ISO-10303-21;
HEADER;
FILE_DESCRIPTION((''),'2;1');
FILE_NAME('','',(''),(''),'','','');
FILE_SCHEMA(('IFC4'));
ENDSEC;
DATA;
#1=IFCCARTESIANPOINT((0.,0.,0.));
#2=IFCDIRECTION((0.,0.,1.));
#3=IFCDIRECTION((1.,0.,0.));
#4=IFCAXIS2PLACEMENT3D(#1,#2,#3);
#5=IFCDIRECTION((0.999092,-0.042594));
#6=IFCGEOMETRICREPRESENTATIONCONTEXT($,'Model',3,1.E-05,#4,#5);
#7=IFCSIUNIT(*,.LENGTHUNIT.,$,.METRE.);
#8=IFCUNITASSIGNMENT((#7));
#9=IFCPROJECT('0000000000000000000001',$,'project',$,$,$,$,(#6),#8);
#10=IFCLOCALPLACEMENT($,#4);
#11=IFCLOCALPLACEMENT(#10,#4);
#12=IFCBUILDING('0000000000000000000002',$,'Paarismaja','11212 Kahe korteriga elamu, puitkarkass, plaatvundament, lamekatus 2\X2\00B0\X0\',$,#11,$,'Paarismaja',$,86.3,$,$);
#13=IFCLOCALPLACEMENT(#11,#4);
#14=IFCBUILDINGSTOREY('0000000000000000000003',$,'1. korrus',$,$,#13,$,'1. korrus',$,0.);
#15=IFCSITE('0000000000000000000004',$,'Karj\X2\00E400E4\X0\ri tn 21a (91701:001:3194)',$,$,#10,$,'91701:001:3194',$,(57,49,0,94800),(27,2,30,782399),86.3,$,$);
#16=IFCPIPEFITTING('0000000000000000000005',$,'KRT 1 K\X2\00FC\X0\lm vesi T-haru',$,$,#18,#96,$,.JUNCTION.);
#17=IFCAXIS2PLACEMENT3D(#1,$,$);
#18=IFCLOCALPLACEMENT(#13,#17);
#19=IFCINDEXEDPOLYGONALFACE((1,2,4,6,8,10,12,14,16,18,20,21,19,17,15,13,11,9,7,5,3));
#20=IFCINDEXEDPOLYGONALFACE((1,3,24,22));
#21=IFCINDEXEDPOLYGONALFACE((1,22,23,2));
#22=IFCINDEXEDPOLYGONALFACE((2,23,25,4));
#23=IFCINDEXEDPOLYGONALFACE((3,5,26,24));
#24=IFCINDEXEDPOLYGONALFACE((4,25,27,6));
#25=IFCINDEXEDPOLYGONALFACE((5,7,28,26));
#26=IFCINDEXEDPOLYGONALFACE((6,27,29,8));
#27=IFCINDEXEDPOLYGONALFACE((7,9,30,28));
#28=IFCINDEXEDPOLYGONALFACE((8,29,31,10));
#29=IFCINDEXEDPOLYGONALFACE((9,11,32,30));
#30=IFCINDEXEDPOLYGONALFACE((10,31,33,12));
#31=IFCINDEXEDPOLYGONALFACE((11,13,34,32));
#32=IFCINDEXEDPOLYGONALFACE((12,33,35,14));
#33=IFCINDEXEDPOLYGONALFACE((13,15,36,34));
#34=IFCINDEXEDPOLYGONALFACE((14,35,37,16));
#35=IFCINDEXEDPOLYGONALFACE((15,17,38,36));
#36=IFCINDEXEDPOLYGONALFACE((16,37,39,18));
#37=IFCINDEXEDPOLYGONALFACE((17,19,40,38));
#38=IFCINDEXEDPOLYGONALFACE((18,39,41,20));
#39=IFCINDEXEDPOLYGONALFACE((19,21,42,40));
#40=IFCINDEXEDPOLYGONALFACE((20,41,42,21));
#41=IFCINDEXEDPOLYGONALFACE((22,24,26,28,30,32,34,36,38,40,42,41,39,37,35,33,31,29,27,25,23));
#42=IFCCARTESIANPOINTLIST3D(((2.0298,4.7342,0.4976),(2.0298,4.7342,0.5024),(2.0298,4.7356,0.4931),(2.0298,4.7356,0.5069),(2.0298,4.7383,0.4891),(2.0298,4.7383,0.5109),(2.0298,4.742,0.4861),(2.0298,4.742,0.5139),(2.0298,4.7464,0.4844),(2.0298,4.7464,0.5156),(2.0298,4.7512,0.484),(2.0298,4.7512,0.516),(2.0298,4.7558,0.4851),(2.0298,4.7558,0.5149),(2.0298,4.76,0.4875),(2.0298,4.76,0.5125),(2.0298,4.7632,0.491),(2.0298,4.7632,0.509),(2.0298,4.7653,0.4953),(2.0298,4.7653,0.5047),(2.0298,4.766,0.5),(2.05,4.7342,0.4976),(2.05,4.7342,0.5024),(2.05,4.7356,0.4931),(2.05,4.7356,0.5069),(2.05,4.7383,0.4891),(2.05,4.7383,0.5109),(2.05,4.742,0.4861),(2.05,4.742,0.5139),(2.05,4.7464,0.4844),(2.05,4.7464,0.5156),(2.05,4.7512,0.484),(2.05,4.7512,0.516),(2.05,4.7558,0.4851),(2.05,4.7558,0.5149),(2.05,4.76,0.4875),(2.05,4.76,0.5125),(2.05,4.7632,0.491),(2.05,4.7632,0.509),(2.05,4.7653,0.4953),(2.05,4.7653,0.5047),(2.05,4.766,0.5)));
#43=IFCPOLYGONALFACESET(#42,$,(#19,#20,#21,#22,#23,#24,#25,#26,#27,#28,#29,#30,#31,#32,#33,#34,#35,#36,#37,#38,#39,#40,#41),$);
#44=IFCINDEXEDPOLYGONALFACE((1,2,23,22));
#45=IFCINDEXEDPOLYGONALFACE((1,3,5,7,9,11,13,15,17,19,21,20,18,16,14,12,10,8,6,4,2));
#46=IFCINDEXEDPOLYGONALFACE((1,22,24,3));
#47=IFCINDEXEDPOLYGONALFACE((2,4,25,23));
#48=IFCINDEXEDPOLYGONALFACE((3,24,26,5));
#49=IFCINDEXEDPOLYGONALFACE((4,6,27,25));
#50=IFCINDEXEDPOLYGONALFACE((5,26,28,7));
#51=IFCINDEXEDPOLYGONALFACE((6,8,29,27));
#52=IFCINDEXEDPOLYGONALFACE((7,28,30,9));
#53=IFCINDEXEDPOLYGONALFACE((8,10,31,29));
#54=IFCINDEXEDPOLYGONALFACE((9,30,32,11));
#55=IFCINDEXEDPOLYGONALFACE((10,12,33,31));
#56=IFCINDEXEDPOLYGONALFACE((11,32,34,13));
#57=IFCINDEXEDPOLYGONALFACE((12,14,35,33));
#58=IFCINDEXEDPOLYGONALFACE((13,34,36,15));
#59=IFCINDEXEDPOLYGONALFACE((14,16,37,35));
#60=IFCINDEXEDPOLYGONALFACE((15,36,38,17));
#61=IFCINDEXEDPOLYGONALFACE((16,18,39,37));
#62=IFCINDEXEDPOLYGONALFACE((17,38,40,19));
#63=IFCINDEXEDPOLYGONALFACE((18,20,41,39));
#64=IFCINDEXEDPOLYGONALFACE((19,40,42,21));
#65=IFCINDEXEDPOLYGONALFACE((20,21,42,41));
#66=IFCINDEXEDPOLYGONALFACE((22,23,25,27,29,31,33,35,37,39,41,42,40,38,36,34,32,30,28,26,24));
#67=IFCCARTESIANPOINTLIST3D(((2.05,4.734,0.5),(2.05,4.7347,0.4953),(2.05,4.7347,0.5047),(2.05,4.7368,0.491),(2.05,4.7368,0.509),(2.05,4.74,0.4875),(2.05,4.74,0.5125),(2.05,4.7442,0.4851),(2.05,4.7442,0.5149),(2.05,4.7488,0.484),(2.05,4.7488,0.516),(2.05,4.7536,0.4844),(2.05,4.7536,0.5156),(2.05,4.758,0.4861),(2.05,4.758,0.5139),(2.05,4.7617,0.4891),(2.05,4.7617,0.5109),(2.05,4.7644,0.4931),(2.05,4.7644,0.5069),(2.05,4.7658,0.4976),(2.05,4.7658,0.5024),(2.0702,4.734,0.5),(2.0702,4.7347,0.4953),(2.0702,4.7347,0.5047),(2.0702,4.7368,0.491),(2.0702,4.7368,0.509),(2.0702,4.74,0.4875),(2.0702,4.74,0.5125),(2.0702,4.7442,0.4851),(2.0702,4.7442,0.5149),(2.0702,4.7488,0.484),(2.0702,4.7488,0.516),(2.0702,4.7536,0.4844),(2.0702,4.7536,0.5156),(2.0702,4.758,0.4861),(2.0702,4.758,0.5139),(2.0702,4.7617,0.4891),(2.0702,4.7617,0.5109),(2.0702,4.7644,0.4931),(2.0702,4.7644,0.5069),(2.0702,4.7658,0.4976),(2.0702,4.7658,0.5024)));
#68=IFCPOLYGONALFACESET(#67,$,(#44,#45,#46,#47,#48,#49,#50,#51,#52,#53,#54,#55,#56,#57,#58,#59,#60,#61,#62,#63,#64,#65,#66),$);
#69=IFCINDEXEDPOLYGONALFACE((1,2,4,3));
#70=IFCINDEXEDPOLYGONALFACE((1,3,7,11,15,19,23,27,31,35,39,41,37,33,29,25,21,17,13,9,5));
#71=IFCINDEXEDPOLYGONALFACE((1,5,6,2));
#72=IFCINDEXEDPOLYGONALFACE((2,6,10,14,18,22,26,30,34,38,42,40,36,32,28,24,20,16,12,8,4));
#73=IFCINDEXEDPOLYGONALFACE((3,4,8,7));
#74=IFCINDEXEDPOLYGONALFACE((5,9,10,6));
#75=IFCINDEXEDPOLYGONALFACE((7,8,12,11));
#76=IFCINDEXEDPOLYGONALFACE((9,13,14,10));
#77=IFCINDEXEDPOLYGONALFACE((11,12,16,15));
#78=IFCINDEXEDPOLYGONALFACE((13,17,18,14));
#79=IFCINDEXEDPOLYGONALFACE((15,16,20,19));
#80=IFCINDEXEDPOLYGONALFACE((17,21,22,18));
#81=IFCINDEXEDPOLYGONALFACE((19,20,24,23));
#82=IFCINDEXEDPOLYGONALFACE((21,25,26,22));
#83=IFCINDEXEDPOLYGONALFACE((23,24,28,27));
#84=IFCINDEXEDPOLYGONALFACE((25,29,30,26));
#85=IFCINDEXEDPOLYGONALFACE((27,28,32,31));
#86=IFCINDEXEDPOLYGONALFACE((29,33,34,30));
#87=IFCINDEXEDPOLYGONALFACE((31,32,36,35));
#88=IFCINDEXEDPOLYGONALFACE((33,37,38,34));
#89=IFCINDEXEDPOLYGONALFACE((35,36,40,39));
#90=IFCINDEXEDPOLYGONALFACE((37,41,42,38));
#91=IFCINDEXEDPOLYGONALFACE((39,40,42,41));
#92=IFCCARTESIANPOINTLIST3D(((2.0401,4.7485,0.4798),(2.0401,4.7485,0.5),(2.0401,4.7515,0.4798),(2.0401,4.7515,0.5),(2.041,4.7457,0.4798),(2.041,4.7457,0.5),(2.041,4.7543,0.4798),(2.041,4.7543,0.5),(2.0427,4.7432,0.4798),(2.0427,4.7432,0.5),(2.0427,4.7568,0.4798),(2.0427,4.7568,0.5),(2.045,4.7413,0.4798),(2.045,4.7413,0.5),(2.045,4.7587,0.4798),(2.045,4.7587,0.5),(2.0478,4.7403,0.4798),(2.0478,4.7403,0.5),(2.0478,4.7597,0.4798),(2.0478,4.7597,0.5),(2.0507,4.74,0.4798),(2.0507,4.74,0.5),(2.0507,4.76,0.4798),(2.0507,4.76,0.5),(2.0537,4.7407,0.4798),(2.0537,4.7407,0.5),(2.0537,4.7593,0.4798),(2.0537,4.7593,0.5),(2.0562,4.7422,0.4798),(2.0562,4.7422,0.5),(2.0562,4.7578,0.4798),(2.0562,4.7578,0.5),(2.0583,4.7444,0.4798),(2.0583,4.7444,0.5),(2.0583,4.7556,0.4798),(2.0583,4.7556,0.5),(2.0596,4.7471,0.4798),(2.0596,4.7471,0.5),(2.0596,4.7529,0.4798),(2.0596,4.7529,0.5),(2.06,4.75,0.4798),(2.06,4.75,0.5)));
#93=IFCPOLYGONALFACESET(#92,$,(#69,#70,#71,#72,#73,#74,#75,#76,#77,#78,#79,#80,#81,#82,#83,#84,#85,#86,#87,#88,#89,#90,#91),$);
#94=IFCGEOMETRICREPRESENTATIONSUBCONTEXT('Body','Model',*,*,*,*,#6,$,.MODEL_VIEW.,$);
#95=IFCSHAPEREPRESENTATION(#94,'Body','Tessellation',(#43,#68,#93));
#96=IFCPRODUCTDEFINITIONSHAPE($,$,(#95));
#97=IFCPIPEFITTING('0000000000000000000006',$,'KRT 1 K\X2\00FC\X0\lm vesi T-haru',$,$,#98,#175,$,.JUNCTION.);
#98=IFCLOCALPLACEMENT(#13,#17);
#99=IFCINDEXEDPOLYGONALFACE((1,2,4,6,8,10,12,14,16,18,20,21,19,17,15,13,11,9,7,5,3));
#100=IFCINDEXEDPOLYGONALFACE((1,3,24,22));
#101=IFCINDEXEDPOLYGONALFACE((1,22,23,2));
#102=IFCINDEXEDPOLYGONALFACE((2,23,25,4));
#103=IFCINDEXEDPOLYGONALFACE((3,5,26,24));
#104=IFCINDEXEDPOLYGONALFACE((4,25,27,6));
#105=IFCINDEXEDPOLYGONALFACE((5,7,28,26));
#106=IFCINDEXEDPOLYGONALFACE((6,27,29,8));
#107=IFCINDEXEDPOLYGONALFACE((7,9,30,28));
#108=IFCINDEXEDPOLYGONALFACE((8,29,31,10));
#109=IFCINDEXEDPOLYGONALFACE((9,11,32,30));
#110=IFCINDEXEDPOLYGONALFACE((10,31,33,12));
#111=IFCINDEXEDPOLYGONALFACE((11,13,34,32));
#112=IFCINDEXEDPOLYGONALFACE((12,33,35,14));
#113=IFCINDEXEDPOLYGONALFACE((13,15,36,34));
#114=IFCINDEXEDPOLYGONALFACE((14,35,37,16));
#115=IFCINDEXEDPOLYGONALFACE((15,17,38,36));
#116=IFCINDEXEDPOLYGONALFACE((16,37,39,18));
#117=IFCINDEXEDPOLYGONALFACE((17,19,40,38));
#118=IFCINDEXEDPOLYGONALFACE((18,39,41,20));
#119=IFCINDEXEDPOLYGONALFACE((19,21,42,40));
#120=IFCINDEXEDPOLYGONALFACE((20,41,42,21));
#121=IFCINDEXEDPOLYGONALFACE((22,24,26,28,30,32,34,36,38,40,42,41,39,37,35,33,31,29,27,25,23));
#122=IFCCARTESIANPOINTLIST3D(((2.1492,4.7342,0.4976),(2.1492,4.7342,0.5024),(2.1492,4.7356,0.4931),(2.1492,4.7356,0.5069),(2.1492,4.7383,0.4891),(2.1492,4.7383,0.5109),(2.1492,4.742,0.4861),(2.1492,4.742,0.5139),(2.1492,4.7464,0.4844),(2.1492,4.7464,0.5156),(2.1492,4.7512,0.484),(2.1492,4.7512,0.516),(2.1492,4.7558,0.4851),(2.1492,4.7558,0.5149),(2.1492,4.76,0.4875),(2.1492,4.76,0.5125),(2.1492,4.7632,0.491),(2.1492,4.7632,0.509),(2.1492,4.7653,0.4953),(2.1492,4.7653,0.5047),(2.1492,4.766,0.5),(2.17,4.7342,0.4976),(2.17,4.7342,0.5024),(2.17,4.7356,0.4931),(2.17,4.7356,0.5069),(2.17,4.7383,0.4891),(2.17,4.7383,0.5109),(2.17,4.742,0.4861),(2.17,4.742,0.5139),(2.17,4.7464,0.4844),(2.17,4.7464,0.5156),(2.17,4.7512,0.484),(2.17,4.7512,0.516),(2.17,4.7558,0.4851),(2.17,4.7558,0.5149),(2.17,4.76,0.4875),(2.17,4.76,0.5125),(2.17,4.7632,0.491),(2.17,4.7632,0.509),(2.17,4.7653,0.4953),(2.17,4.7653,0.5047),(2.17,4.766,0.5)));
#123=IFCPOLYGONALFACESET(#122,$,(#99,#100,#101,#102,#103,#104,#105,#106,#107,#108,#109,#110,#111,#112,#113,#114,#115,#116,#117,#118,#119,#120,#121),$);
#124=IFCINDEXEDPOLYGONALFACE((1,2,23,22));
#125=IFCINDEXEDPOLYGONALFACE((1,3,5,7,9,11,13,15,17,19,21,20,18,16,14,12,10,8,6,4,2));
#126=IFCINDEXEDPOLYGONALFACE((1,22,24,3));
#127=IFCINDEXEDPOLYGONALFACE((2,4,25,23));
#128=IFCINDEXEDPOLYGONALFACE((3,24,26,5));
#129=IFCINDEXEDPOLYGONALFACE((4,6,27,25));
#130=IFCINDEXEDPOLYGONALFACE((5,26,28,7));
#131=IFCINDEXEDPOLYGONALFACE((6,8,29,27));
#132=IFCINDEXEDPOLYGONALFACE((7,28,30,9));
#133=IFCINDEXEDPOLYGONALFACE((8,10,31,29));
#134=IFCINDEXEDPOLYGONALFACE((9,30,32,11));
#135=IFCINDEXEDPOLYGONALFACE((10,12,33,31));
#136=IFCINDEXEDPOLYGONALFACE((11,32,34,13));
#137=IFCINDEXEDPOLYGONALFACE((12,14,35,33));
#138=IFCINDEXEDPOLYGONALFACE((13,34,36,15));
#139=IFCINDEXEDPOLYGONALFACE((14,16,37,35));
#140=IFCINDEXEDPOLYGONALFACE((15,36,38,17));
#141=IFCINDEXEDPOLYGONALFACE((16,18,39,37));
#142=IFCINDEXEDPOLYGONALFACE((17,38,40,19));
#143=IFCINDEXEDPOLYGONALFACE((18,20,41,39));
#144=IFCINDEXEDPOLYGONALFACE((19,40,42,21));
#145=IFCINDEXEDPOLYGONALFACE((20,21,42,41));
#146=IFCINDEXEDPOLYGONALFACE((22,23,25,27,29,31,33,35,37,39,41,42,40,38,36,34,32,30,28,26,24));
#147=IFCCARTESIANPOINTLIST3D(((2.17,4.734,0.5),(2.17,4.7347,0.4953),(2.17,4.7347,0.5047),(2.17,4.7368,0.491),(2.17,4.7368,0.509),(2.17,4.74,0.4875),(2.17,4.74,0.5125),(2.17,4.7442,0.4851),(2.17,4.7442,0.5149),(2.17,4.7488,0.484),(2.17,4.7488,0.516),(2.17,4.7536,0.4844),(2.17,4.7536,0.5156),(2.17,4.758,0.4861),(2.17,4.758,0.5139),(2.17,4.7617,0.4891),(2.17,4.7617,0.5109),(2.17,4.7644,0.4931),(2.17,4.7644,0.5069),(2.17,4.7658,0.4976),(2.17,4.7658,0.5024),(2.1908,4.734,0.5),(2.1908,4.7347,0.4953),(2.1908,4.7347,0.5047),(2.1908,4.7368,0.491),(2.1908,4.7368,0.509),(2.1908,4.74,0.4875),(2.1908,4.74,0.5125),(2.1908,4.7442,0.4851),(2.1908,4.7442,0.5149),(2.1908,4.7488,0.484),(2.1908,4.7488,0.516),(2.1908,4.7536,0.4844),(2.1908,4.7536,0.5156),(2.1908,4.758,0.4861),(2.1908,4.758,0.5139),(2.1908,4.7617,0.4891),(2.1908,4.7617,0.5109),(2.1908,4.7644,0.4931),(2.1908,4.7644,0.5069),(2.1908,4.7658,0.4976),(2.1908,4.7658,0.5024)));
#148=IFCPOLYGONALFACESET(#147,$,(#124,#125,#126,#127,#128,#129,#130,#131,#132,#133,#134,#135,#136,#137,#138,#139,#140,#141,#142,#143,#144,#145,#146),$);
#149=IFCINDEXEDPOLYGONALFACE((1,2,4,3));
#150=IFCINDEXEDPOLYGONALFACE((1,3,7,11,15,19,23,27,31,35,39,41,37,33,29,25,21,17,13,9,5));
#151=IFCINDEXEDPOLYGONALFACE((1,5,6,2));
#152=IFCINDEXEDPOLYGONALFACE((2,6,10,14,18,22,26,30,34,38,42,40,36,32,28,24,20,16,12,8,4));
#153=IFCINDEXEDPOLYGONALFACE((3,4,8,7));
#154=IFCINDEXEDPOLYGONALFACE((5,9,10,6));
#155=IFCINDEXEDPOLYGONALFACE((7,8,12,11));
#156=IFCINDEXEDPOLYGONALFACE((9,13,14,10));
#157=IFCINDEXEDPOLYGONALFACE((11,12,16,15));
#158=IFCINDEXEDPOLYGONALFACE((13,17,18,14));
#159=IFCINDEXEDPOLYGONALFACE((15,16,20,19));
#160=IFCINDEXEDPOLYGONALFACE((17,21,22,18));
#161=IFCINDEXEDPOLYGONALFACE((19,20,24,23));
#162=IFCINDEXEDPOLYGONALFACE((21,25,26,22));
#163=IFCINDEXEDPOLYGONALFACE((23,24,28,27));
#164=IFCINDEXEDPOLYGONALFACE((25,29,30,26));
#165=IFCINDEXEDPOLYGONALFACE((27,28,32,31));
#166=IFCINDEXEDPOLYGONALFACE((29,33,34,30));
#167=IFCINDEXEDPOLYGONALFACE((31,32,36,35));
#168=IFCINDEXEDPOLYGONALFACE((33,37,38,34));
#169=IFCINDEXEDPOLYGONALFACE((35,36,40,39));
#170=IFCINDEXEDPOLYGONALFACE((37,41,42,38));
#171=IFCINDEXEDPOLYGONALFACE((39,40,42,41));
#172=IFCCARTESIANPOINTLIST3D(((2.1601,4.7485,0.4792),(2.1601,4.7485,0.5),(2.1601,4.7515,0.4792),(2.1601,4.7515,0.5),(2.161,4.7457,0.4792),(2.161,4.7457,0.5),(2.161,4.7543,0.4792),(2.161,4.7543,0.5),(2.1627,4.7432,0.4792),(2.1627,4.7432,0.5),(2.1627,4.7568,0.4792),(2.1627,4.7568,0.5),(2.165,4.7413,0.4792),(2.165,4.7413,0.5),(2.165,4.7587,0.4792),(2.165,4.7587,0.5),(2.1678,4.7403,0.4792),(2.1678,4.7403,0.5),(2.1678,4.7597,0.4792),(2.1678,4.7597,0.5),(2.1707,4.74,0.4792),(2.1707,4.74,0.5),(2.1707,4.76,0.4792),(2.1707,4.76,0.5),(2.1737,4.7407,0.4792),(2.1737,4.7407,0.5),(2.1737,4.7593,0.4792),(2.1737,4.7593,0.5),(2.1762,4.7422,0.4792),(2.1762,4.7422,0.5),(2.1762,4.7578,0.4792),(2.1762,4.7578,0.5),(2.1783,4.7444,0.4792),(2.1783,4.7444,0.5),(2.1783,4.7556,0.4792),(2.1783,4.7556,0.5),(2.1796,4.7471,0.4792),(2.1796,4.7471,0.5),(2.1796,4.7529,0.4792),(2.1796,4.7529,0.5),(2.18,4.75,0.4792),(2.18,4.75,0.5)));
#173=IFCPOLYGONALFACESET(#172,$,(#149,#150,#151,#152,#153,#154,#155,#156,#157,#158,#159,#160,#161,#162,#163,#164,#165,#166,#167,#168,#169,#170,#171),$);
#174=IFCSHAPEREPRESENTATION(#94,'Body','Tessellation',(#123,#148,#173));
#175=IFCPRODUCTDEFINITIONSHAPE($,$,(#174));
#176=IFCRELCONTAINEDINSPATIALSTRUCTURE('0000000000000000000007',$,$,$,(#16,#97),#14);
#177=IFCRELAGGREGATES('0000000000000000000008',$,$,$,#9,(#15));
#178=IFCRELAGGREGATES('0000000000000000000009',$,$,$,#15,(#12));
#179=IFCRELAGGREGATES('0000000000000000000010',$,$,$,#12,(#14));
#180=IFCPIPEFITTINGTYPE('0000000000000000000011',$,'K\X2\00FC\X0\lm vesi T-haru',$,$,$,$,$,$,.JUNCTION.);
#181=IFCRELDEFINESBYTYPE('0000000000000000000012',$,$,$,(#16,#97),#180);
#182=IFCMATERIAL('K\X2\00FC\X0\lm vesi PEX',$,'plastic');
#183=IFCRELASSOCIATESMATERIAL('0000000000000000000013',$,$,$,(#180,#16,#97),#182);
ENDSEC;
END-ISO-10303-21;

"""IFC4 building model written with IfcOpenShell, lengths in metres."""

from ifc_helpers import new_model, si_unit, direction, frame, origin_with_axes, place, context, subcontext, project, spatial, circle, extrude, material, type_object, element, save


model = new_model("IFC4")

# Units and contexts
model_context = context("Model", 3, precision=1e-05, world=origin_with_axes(), true_north=direction((0.999092, -0.042594)))
body_context = subcontext(model_context, "Body", "Model", "MODEL_VIEW")
ifc_project = project(units=[si_unit("LENGTHUNIT", "METRE")], contexts=[model_context])

# Site, building, storey
site_placement = place(None, origin_with_axes())
site = spatial("IfcSite", under=ifc_project, at=site_placement, Name="Karjääri tn 21a (91701:001:3194)", LongName="91701:001:3194", RefLatitude=(57, 49, 0, 94800), RefLongitude=(27, 2, 30, 782399), RefElevation=86.3)
building_placement = place(site_placement, origin_with_axes())
building = spatial("IfcBuilding", under=site, at=building_placement, Name="Paarismaja", Description="11212 Kahe korteriga elamu, puitkarkass, plaatvundament, lamekatus 2°", LongName="Paarismaja", ElevationOfRefHeight=86.3)
storey_placement = place(building_placement, origin_with_axes())
storey = spatial("IfcBuildingStorey", under=building, at=storey_placement, Name="1. korrus", LongName="1. korrus", Elevation=0.0)

# Pipe fittings
ifc_material_1 = material(Name="Külm vesi PEX", Category="plastic")
pipe_fitting_type_1 = type_object("IfcPipeFittingType", Name="Külm vesi T-haru", PredefinedType="JUNCTION", material=ifc_material_1)
pipe_fitting_1_placement = place(storey_placement, frame((2.05, 4.75, 0.5), z_axis=(0.0, 0.0, 1.0), x_axis=(1.0, 0.0, 0.0)))
element("IfcPipeFitting", 1, at=pipe_fitting_1_placement, inside=storey, type_object=pipe_fitting_type_1, material=ifc_material_1, Name="KRT 1 Külm vesi T-haru", PredefinedType="JUNCTION", context=body_context, shape_type="SweptSolid", body=[
    extrude(circle(Radius=0.016), frame((0.0, 0.0, 0.0), z_axis=(-1.0, 0.0, 0.0), x_axis=(0.0, 1.0, 0.0)), (0.0, 0.0, 1.0), 0.0202),
    extrude(circle(Radius=0.016), frame((0.0, 0.0, 0.0), z_axis=(1.0, 0.0, 0.0), x_axis=(0.0, -1.0, 0.0)), (0.0, 0.0, 1.0), 0.0202),
    extrude(circle(Radius=0.01), frame((0.0, 0.0, 0.0), z_axis=(0.0, 0.0, -1.0), x_axis=(1.0, 0.0, 0.0)), (0.0, 0.0, 1.0), 0.0202),
])
for number, where, z_axis, x_axis, name in (
    (2, (2.17, 4.75, 0.5), (0.0, 0.0, 1.0), (1.0, 0.0, 0.0), "KRT 1 Külm vesi T-haru"),
):
    element("IfcPipeFitting", number, at=place(storey_placement, frame(where, z_axis=z_axis, x_axis=x_axis)), inside=storey, type_object=pipe_fitting_type_1, material=ifc_material_1, Name=name, PredefinedType="JUNCTION", context=body_context, shape_type="SweptSolid", body=[
        extrude(circle(Radius=0.016), frame((0.0, 0.0, 0.0), z_axis=(-1.0, 0.0, 0.0), x_axis=(0.0, 1.0, 0.0)), (0.0, 0.0, 1.0), 0.0208),
        extrude(circle(Radius=0.016), frame((0.0, 0.0, 0.0), z_axis=(1.0, 0.0, 0.0), x_axis=(0.0, -1.0, 0.0)), (0.0, 0.0, 1.0), 0.0208),
        extrude(circle(Radius=0.01), frame((0.0, 0.0, 0.0), z_axis=(0.0, 0.0, -1.0), x_axis=(1.0, 0.0, 0.0)), (0.0, 0.0, 1.0), 0.0208),
    ])

save(model, "model.ifc")
